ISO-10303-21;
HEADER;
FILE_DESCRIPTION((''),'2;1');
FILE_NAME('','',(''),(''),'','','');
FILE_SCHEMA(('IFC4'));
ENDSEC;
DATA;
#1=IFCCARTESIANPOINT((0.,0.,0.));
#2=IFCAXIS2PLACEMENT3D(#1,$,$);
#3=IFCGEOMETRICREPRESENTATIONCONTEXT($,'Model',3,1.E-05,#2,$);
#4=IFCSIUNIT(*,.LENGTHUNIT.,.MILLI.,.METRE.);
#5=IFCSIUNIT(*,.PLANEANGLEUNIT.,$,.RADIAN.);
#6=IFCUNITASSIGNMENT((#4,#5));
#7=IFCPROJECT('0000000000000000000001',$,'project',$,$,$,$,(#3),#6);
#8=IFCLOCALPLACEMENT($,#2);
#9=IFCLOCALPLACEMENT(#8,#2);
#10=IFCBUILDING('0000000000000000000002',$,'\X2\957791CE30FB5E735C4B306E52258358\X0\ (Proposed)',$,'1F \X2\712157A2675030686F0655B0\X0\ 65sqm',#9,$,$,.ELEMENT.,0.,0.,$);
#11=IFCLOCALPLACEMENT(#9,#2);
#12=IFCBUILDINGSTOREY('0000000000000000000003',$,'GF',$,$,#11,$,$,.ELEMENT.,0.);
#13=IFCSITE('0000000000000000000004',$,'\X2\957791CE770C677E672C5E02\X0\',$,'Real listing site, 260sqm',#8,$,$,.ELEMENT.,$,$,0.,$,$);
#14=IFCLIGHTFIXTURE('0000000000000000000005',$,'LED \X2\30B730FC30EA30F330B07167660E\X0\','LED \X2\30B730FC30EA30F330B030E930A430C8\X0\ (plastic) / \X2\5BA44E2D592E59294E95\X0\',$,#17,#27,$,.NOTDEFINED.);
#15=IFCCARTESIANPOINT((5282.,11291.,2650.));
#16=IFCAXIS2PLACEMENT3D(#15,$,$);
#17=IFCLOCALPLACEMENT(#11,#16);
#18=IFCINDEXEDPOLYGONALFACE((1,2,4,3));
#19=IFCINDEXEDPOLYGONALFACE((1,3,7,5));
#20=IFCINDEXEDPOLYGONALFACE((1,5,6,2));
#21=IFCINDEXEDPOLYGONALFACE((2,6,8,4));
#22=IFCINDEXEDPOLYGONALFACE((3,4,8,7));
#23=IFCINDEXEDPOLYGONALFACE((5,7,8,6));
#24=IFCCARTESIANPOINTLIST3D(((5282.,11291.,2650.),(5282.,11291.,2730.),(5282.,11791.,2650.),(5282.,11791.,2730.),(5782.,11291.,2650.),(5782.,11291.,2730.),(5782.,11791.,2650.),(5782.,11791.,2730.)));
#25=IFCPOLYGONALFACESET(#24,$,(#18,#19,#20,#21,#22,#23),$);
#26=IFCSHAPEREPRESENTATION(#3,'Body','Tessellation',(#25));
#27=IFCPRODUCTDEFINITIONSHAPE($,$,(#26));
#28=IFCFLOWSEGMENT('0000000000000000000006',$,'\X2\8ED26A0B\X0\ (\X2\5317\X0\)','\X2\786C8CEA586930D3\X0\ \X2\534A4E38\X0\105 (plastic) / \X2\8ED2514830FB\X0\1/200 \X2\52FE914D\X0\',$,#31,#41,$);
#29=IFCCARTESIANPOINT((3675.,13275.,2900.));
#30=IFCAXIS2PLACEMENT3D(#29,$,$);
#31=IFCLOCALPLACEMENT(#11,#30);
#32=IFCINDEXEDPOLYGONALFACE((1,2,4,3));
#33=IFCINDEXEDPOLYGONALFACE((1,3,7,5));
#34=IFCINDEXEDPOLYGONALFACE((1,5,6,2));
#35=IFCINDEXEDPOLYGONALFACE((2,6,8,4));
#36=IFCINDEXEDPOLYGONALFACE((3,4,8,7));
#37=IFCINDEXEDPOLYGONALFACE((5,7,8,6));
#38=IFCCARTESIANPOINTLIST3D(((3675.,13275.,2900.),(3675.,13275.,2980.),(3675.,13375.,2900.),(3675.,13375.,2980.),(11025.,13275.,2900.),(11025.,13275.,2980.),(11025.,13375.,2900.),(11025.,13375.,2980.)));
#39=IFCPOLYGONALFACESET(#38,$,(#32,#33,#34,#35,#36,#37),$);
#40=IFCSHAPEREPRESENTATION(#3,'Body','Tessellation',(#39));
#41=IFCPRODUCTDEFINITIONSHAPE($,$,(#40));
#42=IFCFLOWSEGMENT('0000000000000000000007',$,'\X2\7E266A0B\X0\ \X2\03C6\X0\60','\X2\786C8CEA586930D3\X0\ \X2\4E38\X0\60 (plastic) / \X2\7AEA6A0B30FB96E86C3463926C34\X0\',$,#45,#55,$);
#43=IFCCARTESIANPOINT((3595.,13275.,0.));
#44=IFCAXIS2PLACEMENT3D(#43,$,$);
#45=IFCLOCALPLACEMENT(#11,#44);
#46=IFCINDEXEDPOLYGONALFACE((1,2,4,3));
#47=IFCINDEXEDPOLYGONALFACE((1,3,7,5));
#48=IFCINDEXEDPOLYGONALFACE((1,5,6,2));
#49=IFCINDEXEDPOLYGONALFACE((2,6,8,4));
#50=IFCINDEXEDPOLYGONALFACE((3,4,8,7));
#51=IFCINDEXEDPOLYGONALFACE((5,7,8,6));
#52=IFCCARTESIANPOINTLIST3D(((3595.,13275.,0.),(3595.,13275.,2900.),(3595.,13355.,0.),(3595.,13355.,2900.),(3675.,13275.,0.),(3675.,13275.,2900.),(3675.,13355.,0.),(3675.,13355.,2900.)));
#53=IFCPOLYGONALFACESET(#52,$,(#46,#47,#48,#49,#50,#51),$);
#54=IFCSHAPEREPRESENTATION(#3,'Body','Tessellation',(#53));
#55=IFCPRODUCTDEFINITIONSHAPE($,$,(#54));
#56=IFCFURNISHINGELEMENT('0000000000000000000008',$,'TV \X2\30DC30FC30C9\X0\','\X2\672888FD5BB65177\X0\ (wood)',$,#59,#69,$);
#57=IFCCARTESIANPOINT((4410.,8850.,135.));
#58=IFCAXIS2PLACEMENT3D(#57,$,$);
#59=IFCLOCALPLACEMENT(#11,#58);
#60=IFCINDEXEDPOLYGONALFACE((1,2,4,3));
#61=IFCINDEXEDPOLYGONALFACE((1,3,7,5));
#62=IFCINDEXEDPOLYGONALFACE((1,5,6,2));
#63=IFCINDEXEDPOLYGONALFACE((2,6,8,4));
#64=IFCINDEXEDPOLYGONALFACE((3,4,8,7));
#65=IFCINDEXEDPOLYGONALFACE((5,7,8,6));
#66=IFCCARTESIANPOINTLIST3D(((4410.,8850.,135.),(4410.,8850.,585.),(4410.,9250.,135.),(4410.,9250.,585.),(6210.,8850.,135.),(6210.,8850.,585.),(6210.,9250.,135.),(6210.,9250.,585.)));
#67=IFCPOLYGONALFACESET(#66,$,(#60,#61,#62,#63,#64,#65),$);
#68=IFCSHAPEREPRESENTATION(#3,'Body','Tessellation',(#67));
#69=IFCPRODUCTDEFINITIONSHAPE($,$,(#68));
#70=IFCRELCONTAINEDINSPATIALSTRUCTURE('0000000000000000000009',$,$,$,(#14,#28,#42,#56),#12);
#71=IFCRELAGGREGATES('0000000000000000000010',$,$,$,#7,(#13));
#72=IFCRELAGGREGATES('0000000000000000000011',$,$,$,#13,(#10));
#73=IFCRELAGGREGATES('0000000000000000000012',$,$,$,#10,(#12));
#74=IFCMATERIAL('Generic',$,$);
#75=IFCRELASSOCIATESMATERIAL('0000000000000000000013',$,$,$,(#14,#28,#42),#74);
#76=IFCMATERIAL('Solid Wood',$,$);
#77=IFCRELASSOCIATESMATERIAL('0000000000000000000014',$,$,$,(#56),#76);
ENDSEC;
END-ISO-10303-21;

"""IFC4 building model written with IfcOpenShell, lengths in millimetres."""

from ifc_helpers import new_model, si_unit, frame, frame_2d, origin, place, context, project, spatial, rectangle, extrude, material, element, save


model = new_model("IFC4")

# Units and contexts
model_context = context("Model", 3, precision=1e-05, world=origin())
ifc_project = project(units=[si_unit("LENGTHUNIT", "METRE", prefix="MILLI"), si_unit("PLANEANGLEUNIT", "RADIAN")], contexts=[model_context])

# Site, building, storey
site_placement = place(None, origin())
site = spatial("IfcSite", under=ifc_project, at=site_placement, Name="長野県松本市", ObjectType="Real listing site, 260sqm", CompositionType="ELEMENT", RefElevation=0.0)
building_placement = place(site_placement, origin())
building = spatial("IfcBuilding", under=site, at=building_placement, Name="長野・平屋の別荘 (Proposed)", ObjectType="1F 無垢材と漆喰 65sqm", CompositionType="ELEMENT", ElevationOfRefHeight=0.0, ElevationOfTerrain=0.0)
storey_placement = place(building_placement, origin())
storey = spatial("IfcBuildingStorey", under=building, at=storey_placement, Name="GF", CompositionType="ELEMENT", Elevation=0.0)

# Shared definitions
ifc_material_1 = material(Name="Solid Wood")

# Shared definitions
ifc_material_2 = material(Name="Generic")

# Light fixture
light_fixture_placement = place(storey_placement, frame((5282.0, 11291.0, 2650.0)))
element("IfcLightFixture", 1, at=light_fixture_placement, inside=storey, material=ifc_material_2, Name="LED シーリング照明", Description="LED シーリングライト (plastic) / 室中央天井", PredefinedType="NOTDEFINED", context=model_context, shape_type="SweptSolid", body=[
    extrude(rectangle(XDim=500.0, YDim=500.0, at=frame_2d((250.0, 250.0))), frame((5282.0, 11291.0, 2650.0)), (0.0, 0.0, 1.0), 80.0),
])

# Flow segments
flow_segment_1_placement = place(storey_placement, frame((3675.0, 13275.0, 2900.0)))
element("IfcFlowSegment", 2, at=flow_segment_1_placement, inside=storey, material=ifc_material_2, Name="軒樋 (北)", Description="硬質塩ビ 半丸105 (plastic) / 軒先・1/200 勾配", context=model_context, shape_type="SweptSolid", body=[
    extrude(rectangle(XDim=7350.0, YDim=100.0, at=frame_2d((3675.0, 50.0))), frame((3675.0, 13275.0, 2900.0)), (0.0, 0.0, 1.0), 80.0),
])
flow_segment_2_placement = place(storey_placement, frame((3595.0, 13275.0, 0.0)))
element("IfcFlowSegment", 3, at=flow_segment_2_placement, inside=storey, material=ifc_material_2, Name="縦樋 φ60", Description="硬質塩ビ 丸60 (plastic) / 竪樋・雨水排水", context=model_context, shape_type="SweptSolid", body=[
    extrude(rectangle(XDim=80.0, YDim=80.0, at=frame_2d((40.0, 40.0))), frame((3595.0, 13275.0, 0.0)), (0.0, 0.0, 1.0), 2900.0),
])

# Furnishing element
furnishing_placement = place(storey_placement, frame((4410.0, 8850.0, 135.0)))
element("IfcFurnishingElement", 4, at=furnishing_placement, inside=storey, material=ifc_material_1, Name="TV ボード", Description="木製家具 (wood)", context=model_context, shape_type="SweptSolid", body=[
    extrude(rectangle(XDim=1800.0, YDim=400.0, at=frame_2d((900.0, 200.0))), frame((4410.0, 8850.0, 135.0)), (0.0, 0.0, 1.0), 450.0),
])

save(model, "model.ifc")
